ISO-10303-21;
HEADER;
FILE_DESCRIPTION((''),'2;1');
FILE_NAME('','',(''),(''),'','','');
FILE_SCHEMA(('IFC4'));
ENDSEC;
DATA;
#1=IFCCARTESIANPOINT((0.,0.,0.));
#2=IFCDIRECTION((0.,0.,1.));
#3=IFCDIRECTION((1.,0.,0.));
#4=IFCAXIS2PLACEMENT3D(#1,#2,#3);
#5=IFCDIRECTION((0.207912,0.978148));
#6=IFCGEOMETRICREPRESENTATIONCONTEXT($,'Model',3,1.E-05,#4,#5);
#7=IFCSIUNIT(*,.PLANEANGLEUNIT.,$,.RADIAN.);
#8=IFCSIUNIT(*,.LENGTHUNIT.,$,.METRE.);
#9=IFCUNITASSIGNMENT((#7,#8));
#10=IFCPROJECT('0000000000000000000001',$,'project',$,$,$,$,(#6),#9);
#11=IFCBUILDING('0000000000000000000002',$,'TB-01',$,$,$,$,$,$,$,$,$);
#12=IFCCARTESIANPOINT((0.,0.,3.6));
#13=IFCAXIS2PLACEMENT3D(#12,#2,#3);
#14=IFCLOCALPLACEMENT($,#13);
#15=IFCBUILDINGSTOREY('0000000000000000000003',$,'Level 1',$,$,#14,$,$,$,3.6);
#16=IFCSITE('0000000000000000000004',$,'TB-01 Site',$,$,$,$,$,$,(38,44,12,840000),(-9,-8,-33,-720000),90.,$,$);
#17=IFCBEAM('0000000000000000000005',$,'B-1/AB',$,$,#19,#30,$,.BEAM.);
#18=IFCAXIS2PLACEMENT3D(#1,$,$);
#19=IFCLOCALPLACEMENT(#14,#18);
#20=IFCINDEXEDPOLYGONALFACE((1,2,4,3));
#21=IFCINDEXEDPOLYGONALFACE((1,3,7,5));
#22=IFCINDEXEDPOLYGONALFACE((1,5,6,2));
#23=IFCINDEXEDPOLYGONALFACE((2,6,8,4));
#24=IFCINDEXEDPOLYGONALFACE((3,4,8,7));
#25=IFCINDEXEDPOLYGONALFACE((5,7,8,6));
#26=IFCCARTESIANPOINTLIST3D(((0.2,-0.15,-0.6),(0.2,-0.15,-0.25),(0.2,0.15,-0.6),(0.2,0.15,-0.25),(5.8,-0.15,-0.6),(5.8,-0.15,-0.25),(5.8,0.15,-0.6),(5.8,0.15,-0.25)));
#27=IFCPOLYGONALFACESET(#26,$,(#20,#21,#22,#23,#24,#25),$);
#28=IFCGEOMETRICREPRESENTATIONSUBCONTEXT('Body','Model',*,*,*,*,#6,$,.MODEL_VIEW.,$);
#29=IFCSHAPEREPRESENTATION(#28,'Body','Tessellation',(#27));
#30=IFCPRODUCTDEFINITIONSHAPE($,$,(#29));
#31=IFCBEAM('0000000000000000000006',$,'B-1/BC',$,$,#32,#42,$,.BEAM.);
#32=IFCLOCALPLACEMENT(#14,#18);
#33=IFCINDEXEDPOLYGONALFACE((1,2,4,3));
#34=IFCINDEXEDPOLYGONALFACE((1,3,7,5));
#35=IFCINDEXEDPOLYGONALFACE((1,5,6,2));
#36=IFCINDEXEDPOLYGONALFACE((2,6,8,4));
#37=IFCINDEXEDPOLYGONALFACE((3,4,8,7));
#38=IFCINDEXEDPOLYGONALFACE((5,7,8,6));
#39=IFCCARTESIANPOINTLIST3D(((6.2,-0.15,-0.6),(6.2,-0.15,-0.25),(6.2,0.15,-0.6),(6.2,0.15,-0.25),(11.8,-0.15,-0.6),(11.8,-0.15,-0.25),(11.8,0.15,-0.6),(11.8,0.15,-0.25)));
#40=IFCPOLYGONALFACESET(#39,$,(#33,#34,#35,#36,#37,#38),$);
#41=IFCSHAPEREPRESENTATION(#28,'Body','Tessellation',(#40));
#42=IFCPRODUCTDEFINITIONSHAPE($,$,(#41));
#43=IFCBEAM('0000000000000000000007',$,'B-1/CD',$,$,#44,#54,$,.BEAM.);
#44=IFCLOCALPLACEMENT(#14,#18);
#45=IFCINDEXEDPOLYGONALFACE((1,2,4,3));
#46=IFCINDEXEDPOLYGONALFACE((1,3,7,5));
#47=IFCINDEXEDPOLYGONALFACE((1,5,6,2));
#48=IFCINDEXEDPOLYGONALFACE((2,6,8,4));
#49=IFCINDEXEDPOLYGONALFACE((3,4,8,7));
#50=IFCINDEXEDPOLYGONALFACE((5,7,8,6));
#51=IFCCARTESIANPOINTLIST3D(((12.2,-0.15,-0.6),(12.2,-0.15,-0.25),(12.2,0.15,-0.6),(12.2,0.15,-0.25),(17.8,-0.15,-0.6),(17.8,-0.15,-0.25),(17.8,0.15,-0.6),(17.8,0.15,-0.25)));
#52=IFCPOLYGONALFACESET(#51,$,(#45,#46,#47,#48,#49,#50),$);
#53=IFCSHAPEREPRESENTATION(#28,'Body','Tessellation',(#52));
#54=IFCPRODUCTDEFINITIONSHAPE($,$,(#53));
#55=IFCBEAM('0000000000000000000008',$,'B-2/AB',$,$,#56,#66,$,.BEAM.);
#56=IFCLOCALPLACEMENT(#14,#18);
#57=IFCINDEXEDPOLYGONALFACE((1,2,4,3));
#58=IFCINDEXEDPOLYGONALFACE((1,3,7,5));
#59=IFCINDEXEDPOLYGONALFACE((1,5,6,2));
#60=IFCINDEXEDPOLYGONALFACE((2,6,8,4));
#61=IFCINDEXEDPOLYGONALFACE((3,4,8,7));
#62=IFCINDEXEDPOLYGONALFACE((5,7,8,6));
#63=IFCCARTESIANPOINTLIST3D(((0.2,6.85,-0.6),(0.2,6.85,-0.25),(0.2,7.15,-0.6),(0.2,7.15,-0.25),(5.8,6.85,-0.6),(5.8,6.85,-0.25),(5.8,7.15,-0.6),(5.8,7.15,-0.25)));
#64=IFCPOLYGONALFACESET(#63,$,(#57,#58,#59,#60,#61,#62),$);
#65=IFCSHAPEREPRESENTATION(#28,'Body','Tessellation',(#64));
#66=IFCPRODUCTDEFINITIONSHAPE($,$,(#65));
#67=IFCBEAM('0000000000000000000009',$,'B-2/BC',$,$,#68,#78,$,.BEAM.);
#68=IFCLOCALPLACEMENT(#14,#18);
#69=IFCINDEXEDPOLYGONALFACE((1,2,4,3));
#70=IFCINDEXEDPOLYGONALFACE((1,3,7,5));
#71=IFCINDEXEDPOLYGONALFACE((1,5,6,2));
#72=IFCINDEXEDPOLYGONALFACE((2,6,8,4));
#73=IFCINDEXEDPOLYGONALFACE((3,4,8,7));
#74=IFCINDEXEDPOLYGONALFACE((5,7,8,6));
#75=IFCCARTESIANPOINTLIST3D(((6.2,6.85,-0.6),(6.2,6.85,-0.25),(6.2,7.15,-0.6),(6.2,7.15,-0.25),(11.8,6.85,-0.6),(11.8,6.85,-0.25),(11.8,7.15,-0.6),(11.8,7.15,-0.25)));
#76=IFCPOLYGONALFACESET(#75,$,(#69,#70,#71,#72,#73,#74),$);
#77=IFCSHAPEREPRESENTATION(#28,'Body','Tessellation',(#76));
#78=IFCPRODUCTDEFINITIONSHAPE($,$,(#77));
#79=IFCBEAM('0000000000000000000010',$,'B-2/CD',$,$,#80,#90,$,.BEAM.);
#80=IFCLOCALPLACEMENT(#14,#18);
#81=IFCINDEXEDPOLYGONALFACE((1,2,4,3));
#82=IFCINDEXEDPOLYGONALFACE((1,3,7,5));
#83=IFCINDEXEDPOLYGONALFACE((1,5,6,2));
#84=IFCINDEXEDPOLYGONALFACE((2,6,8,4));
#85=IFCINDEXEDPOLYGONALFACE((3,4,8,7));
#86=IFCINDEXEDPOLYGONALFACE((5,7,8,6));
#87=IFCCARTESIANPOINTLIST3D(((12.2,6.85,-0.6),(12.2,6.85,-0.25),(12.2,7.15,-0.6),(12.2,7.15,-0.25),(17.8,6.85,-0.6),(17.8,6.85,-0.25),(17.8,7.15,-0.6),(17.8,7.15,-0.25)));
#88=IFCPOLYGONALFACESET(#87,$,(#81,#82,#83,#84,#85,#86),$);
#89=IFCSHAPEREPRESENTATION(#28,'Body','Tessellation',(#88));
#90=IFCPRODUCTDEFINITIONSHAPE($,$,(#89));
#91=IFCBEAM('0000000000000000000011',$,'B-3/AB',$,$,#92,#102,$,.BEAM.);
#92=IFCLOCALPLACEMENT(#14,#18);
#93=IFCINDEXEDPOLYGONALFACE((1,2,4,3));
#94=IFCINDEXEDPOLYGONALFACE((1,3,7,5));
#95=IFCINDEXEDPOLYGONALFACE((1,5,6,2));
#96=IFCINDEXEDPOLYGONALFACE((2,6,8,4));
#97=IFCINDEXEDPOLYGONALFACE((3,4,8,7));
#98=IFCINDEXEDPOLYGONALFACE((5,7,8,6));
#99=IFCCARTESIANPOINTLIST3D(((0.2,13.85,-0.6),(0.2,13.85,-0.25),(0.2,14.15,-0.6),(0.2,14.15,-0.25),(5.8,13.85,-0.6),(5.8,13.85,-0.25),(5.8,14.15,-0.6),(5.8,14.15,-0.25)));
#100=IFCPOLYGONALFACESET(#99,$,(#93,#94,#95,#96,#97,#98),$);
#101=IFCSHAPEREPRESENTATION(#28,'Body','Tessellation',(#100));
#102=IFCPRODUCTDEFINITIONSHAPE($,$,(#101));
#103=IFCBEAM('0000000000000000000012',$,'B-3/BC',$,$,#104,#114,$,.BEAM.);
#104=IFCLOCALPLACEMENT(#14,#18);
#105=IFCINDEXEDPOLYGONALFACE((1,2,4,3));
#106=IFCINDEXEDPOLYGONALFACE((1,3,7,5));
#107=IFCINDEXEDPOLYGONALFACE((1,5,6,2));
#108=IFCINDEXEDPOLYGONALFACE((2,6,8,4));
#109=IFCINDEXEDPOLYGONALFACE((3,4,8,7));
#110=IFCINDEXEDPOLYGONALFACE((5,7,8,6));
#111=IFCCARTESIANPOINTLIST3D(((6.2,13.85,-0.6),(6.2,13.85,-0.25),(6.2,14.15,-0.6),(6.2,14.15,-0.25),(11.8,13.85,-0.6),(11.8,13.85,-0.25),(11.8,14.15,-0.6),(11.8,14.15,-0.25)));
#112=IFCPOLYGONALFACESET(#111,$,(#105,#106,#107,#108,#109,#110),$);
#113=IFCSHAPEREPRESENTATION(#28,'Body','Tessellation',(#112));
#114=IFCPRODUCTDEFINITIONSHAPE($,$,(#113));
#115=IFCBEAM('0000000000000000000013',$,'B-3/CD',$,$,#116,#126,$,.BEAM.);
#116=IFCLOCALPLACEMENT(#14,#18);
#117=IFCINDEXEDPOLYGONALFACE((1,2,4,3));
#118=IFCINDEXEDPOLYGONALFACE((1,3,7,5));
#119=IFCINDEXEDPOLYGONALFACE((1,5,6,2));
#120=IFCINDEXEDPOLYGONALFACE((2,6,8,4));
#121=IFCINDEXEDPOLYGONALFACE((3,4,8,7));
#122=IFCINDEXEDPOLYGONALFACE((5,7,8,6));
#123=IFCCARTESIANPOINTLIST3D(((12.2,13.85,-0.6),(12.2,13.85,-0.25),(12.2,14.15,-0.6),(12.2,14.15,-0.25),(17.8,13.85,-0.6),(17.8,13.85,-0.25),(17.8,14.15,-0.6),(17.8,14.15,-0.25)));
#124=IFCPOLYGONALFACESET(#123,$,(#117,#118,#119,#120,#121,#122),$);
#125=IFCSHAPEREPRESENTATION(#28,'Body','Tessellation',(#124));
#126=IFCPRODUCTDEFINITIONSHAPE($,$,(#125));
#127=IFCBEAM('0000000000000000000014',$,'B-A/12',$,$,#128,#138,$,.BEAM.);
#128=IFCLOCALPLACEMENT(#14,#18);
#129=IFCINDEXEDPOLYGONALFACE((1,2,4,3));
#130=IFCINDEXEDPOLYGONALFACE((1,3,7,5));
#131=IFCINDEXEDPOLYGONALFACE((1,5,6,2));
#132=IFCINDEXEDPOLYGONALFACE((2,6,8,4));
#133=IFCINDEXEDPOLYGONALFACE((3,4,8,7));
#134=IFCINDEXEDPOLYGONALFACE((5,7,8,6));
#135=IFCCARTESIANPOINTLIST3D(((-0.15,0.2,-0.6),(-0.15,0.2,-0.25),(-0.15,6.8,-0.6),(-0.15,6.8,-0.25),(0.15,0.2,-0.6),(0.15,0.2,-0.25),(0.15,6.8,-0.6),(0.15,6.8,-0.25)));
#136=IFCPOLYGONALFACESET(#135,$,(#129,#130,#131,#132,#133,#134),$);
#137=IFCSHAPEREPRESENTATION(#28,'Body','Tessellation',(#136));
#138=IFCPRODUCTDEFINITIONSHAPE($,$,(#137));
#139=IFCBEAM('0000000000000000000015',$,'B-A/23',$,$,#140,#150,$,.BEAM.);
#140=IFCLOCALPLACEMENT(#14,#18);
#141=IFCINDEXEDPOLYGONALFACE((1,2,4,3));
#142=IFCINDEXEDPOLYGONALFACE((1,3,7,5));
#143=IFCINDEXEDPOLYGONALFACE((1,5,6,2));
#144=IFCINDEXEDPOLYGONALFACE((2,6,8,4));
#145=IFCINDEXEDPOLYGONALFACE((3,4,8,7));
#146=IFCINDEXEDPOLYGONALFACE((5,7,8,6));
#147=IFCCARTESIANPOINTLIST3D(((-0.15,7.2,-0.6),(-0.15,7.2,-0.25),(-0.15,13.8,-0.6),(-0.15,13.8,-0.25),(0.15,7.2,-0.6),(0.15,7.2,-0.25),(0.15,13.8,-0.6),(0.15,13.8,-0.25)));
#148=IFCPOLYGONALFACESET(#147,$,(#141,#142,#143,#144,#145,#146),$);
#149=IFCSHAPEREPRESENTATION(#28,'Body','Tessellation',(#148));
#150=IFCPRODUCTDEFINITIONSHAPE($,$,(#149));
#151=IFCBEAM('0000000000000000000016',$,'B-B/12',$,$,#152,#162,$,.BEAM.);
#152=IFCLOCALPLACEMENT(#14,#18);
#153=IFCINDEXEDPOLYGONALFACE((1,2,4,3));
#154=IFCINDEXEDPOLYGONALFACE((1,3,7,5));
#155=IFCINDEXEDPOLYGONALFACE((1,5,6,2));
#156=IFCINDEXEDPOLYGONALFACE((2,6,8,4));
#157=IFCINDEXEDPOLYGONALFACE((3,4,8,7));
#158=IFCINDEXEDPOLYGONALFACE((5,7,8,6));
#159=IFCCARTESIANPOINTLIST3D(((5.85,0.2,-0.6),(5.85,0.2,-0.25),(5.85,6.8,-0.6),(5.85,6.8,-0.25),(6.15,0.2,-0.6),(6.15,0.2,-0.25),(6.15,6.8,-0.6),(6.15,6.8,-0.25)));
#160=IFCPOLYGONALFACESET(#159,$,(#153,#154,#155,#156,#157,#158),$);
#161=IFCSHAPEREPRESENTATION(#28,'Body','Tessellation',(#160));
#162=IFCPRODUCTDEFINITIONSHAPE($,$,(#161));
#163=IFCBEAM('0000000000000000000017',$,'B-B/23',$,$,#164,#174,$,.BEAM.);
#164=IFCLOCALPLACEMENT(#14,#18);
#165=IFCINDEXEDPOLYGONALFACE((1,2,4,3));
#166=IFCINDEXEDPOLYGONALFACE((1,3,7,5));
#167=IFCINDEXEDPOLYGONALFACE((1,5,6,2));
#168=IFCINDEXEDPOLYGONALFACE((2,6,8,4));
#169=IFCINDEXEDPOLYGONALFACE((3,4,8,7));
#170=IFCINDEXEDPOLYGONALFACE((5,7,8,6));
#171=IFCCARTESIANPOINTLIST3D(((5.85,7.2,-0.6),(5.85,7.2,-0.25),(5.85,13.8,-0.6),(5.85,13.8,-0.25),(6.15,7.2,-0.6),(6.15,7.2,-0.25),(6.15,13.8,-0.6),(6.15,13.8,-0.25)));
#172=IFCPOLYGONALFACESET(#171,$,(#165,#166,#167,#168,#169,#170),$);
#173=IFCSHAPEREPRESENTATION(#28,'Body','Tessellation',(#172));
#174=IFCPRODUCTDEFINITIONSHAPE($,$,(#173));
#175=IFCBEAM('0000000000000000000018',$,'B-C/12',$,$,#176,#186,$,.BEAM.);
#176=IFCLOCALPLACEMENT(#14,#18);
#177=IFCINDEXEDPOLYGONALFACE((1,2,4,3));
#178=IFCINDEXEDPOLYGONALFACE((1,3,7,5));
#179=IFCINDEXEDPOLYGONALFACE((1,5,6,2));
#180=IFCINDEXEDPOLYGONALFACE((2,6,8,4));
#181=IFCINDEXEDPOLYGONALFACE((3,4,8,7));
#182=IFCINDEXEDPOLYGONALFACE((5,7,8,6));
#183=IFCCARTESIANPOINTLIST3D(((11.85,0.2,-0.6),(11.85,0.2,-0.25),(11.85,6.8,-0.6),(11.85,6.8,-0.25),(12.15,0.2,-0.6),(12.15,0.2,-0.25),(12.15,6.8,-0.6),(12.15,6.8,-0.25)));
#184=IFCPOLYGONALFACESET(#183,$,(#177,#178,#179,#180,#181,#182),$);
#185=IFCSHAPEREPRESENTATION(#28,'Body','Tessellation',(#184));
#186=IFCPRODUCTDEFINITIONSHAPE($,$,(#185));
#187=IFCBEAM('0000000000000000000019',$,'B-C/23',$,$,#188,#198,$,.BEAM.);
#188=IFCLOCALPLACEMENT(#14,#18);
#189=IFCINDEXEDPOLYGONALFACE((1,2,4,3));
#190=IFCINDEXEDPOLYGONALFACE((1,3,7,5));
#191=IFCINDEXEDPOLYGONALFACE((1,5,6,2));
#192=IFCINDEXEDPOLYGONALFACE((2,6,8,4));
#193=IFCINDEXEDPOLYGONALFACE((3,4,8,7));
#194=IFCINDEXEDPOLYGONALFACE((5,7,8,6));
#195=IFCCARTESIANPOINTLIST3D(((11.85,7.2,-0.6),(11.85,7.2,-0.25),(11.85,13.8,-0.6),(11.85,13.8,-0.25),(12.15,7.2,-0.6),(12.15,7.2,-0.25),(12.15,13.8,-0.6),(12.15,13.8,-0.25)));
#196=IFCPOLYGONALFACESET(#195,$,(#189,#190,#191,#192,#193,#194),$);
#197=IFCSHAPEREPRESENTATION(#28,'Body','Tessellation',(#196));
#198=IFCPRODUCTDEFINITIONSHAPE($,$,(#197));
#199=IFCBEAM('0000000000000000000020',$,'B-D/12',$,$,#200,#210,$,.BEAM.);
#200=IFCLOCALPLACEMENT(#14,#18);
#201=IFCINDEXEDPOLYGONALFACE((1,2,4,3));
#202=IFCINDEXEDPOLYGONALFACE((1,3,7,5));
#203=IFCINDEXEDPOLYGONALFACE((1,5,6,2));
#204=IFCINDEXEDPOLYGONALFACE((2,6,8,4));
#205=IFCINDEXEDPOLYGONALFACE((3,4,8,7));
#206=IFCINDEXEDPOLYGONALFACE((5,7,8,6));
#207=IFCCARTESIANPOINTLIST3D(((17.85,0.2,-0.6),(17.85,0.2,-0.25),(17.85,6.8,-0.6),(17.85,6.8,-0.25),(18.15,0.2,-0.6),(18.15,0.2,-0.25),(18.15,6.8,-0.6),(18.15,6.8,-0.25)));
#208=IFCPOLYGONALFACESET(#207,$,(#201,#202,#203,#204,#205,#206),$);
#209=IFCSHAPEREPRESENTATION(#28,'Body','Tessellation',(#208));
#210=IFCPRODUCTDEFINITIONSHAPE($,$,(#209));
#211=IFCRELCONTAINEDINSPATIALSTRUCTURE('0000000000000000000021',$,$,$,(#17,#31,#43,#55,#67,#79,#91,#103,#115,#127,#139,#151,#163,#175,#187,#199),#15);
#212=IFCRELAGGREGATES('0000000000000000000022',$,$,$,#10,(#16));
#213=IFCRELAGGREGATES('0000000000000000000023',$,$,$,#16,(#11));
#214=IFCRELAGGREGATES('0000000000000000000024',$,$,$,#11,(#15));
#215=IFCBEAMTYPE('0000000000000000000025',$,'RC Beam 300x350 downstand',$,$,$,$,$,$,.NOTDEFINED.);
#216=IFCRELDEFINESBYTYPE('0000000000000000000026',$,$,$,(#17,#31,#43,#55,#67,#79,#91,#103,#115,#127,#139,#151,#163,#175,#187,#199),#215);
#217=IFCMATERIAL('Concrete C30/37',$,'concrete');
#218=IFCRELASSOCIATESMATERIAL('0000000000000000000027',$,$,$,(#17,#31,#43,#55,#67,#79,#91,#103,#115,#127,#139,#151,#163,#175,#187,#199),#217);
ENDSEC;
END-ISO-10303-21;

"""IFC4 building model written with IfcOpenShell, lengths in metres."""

from ifc_helpers import new_model, si_unit, direction, frame, origin_with_axes, place, context, subcontext, project, spatial, rectangle, extrude, material, type_object, element, save


model = new_model("IFC4")

# Units and contexts
model_context = context("Model", 3, precision=1e-05, world=origin_with_axes(), true_north=direction((0.207912, 0.978148)))
body_context = subcontext(model_context, "Body", "Model", "MODEL_VIEW")
ifc_project = project(units=[si_unit("PLANEANGLEUNIT", "RADIAN"), si_unit("LENGTHUNIT", "METRE")], contexts=[model_context])

# Site, building, storey
site = spatial("IfcSite", under=ifc_project, Name="TB-01 Site", RefLatitude=(38, 44, 12, 840000), RefLongitude=(-9, -8, -33, -720000), RefElevation=90.0)
building = spatial("IfcBuilding", under=site, Name="TB-01")
storey_placement = place(None, frame((0.0, 0.0, 3.6), z_axis=(0.0, 0.0, 1.0), x_axis=(1.0, 0.0, 0.0)))
storey = spatial("IfcBuildingStorey", under=building, at=storey_placement, Name="Level 1", Elevation=3.6)

# Beams
ifc_material = material(Name="Concrete C30/37", Category="concrete")
beam_type = type_object("IfcBeamType", Name="RC Beam 300x350 downstand", PredefinedType="NOTDEFINED")
beam_1_placement = place(storey_placement, frame((0.2, 0.0, -0.425), z_axis=(1.0, 0.0, 0.0), x_axis=(0.0, 1.0, 0.0)))
element("IfcBeam", 1, at=beam_1_placement, inside=storey, type_object=beam_type, material=ifc_material, Name="B-1/AB", PredefinedType="BEAM", context=body_context, shape_type="SweptSolid", body=[
    extrude(rectangle(XDim=0.3, YDim=0.35), origin_with_axes(), (0.0, 0.0, 1.0), 5.6),
])
beam_2_placement = place(storey_placement, frame((6.2, 0.0, -0.425), z_axis=(1.0, 0.0, 0.0), x_axis=(0.0, 1.0, 0.0)))
element("IfcBeam", 2, at=beam_2_placement, inside=storey, type_object=beam_type, material=ifc_material, Name="B-1/BC", PredefinedType="BEAM", context=body_context, shape_type="SweptSolid", body=[
    extrude(rectangle(XDim=0.3, YDim=0.35), origin_with_axes(), (0.0, 0.0, 1.0), 5.6),
])
beam_3_placement = place(storey_placement, frame((12.2, 0.0, -0.425), z_axis=(1.0, 0.0, 0.0), x_axis=(0.0, 1.0, 0.0)))
element("IfcBeam", 3, at=beam_3_placement, inside=storey, type_object=beam_type, material=ifc_material, Name="B-1/CD", PredefinedType="BEAM", context=body_context, shape_type="SweptSolid", body=[
    extrude(rectangle(XDim=0.3, YDim=0.35), origin_with_axes(), (0.0, 0.0, 1.0), 5.6),
])
beam_4_placement = place(storey_placement, frame((0.2, 7.0, -0.425), z_axis=(1.0, 0.0, 0.0), x_axis=(0.0, 1.0, 0.0)))
element("IfcBeam", 4, at=beam_4_placement, inside=storey, type_object=beam_type, material=ifc_material, Name="B-2/AB", PredefinedType="BEAM", context=body_context, shape_type="SweptSolid", body=[
    extrude(rectangle(XDim=0.3, YDim=0.35), origin_with_axes(), (0.0, 0.0, 1.0), 5.6),
])
beam_5_placement = place(storey_placement, frame((6.2, 7.0, -0.425), z_axis=(1.0, 0.0, 0.0), x_axis=(0.0, 1.0, 0.0)))
element("IfcBeam", 5, at=beam_5_placement, inside=storey, type_object=beam_type, material=ifc_material, Name="B-2/BC", PredefinedType="BEAM", context=body_context, shape_type="SweptSolid", body=[
    extrude(rectangle(XDim=0.3, YDim=0.35), origin_with_axes(), (0.0, 0.0, 1.0), 5.6),
])
beam_6_placement = place(storey_placement, frame((12.2, 7.0, -0.425), z_axis=(1.0, 0.0, 0.0), x_axis=(0.0, 1.0, 0.0)))
element("IfcBeam", 6, at=beam_6_placement, inside=storey, type_object=beam_type, material=ifc_material, Name="B-2/CD", PredefinedType="BEAM", context=body_context, shape_type="SweptSolid", body=[
    extrude(rectangle(XDim=0.3, YDim=0.35), origin_with_axes(), (0.0, 0.0, 1.0), 5.6),
])
beam_7_placement = place(storey_placement, frame((0.2, 14.0, -0.425), z_axis=(1.0, 0.0, 0.0), x_axis=(0.0, 1.0, 0.0)))
element("IfcBeam", 7, at=beam_7_placement, inside=storey, type_object=beam_type, material=ifc_material, Name="B-3/AB", PredefinedType="BEAM", context=body_context, shape_type="SweptSolid", body=[
    extrude(rectangle(XDim=0.3, YDim=0.35), origin_with_axes(), (0.0, 0.0, 1.0), 5.6),
])
beam_8_placement = place(storey_placement, frame((6.2, 14.0, -0.425), z_axis=(1.0, 0.0, 0.0), x_axis=(0.0, 1.0, 0.0)))
element("IfcBeam", 8, at=beam_8_placement, inside=storey, type_object=beam_type, material=ifc_material, Name="B-3/BC", PredefinedType="BEAM", context=body_context, shape_type="SweptSolid", body=[
    extrude(rectangle(XDim=0.3, YDim=0.35), origin_with_axes(), (0.0, 0.0, 1.0), 5.6),
])
beam_9_placement = place(storey_placement, frame((12.2, 14.0, -0.425), z_axis=(1.0, 0.0, 0.0), x_axis=(0.0, 1.0, 0.0)))
element("IfcBeam", 9, at=beam_9_placement, inside=storey, type_object=beam_type, material=ifc_material, Name="B-3/CD", PredefinedType="BEAM", context=body_context, shape_type="SweptSolid", body=[
    extrude(rectangle(XDim=0.3, YDim=0.35), origin_with_axes(), (0.0, 0.0, 1.0), 5.6),
])
beam_10_placement = place(storey_placement, frame((0.0, 0.2, -0.425), z_axis=(0.0, 1.0, 0.0), x_axis=(-1.0, 0.0, 0.0)))
element("IfcBeam", 10, at=beam_10_placement, inside=storey, type_object=beam_type, material=ifc_material, Name="B-A/12", PredefinedType="BEAM", context=body_context, shape_type="SweptSolid", body=[
    extrude(rectangle(XDim=0.3, YDim=0.35), origin_with_axes(), (0.0, 0.0, 1.0), 6.6),
])
beam_11_placement = place(storey_placement, frame((0.0, 7.2, -0.425), z_axis=(0.0, 1.0, 0.0), x_axis=(-1.0, 0.0, 0.0)))
element("IfcBeam", 11, at=beam_11_placement, inside=storey, type_object=beam_type, material=ifc_material, Name="B-A/23", PredefinedType="BEAM", context=body_context, shape_type="SweptSolid", body=[
    extrude(rectangle(XDim=0.3, YDim=0.35), origin_with_axes(), (0.0, 0.0, 1.0), 6.6),
])
beam_12_placement = place(storey_placement, frame((6.0, 0.2, -0.425), z_axis=(0.0, 1.0, 0.0), x_axis=(-1.0, 0.0, 0.0)))
element("IfcBeam", 12, at=beam_12_placement, inside=storey, type_object=beam_type, material=ifc_material, Name="B-B/12", PredefinedType="BEAM", context=body_context, shape_type="SweptSolid", body=[
    extrude(rectangle(XDim=0.3, YDim=0.35), origin_with_axes(), (0.0, 0.0, 1.0), 6.6),
])
beam_13_placement = place(storey_placement, frame((6.0, 7.2, -0.425), z_axis=(0.0, 1.0, 0.0), x_axis=(-1.0, 0.0, 0.0)))
element("IfcBeam", 13, at=beam_13_placement, inside=storey, type_object=beam_type, material=ifc_material, Name="B-B/23", PredefinedType="BEAM", context=body_context, shape_type="SweptSolid", body=[
    extrude(rectangle(XDim=0.3, YDim=0.35), origin_with_axes(), (0.0, 0.0, 1.0), 6.6),
])
beam_14_placement = place(storey_placement, frame((12.0, 0.2, -0.425), z_axis=(0.0, 1.0, 0.0), x_axis=(-1.0, 0.0, 0.0)))
element("IfcBeam", 14, at=beam_14_placement, inside=storey, type_object=beam_type, material=ifc_material, Name="B-C/12", PredefinedType="BEAM", context=body_context, shape_type="SweptSolid", body=[
    extrude(rectangle(XDim=0.3, YDim=0.35), origin_with_axes(), (0.0, 0.0, 1.0), 6.6),
])
beam_15_placement = place(storey_placement, frame((12.0, 7.2, -0.425), z_axis=(0.0, 1.0, 0.0), x_axis=(-1.0, 0.0, 0.0)))
element("IfcBeam", 15, at=beam_15_placement, inside=storey, type_object=beam_type, material=ifc_material, Name="B-C/23", PredefinedType="BEAM", context=body_context, shape_type="SweptSolid", body=[
    extrude(rectangle(XDim=0.3, YDim=0.35), origin_with_axes(), (0.0, 0.0, 1.0), 6.6),
])
beam_16_placement = place(storey_placement, frame((18.0, 0.2, -0.425), z_axis=(0.0, 1.0, 0.0), x_axis=(-1.0, 0.0, 0.0)))
element("IfcBeam", 16, at=beam_16_placement, inside=storey, type_object=beam_type, material=ifc_material, Name="B-D/12", PredefinedType="BEAM", context=body_context, shape_type="SweptSolid", body=[
    extrude(rectangle(XDim=0.3, YDim=0.35), origin_with_axes(), (0.0, 0.0, 1.0), 6.6),
])

save(model, "model.ifc")
